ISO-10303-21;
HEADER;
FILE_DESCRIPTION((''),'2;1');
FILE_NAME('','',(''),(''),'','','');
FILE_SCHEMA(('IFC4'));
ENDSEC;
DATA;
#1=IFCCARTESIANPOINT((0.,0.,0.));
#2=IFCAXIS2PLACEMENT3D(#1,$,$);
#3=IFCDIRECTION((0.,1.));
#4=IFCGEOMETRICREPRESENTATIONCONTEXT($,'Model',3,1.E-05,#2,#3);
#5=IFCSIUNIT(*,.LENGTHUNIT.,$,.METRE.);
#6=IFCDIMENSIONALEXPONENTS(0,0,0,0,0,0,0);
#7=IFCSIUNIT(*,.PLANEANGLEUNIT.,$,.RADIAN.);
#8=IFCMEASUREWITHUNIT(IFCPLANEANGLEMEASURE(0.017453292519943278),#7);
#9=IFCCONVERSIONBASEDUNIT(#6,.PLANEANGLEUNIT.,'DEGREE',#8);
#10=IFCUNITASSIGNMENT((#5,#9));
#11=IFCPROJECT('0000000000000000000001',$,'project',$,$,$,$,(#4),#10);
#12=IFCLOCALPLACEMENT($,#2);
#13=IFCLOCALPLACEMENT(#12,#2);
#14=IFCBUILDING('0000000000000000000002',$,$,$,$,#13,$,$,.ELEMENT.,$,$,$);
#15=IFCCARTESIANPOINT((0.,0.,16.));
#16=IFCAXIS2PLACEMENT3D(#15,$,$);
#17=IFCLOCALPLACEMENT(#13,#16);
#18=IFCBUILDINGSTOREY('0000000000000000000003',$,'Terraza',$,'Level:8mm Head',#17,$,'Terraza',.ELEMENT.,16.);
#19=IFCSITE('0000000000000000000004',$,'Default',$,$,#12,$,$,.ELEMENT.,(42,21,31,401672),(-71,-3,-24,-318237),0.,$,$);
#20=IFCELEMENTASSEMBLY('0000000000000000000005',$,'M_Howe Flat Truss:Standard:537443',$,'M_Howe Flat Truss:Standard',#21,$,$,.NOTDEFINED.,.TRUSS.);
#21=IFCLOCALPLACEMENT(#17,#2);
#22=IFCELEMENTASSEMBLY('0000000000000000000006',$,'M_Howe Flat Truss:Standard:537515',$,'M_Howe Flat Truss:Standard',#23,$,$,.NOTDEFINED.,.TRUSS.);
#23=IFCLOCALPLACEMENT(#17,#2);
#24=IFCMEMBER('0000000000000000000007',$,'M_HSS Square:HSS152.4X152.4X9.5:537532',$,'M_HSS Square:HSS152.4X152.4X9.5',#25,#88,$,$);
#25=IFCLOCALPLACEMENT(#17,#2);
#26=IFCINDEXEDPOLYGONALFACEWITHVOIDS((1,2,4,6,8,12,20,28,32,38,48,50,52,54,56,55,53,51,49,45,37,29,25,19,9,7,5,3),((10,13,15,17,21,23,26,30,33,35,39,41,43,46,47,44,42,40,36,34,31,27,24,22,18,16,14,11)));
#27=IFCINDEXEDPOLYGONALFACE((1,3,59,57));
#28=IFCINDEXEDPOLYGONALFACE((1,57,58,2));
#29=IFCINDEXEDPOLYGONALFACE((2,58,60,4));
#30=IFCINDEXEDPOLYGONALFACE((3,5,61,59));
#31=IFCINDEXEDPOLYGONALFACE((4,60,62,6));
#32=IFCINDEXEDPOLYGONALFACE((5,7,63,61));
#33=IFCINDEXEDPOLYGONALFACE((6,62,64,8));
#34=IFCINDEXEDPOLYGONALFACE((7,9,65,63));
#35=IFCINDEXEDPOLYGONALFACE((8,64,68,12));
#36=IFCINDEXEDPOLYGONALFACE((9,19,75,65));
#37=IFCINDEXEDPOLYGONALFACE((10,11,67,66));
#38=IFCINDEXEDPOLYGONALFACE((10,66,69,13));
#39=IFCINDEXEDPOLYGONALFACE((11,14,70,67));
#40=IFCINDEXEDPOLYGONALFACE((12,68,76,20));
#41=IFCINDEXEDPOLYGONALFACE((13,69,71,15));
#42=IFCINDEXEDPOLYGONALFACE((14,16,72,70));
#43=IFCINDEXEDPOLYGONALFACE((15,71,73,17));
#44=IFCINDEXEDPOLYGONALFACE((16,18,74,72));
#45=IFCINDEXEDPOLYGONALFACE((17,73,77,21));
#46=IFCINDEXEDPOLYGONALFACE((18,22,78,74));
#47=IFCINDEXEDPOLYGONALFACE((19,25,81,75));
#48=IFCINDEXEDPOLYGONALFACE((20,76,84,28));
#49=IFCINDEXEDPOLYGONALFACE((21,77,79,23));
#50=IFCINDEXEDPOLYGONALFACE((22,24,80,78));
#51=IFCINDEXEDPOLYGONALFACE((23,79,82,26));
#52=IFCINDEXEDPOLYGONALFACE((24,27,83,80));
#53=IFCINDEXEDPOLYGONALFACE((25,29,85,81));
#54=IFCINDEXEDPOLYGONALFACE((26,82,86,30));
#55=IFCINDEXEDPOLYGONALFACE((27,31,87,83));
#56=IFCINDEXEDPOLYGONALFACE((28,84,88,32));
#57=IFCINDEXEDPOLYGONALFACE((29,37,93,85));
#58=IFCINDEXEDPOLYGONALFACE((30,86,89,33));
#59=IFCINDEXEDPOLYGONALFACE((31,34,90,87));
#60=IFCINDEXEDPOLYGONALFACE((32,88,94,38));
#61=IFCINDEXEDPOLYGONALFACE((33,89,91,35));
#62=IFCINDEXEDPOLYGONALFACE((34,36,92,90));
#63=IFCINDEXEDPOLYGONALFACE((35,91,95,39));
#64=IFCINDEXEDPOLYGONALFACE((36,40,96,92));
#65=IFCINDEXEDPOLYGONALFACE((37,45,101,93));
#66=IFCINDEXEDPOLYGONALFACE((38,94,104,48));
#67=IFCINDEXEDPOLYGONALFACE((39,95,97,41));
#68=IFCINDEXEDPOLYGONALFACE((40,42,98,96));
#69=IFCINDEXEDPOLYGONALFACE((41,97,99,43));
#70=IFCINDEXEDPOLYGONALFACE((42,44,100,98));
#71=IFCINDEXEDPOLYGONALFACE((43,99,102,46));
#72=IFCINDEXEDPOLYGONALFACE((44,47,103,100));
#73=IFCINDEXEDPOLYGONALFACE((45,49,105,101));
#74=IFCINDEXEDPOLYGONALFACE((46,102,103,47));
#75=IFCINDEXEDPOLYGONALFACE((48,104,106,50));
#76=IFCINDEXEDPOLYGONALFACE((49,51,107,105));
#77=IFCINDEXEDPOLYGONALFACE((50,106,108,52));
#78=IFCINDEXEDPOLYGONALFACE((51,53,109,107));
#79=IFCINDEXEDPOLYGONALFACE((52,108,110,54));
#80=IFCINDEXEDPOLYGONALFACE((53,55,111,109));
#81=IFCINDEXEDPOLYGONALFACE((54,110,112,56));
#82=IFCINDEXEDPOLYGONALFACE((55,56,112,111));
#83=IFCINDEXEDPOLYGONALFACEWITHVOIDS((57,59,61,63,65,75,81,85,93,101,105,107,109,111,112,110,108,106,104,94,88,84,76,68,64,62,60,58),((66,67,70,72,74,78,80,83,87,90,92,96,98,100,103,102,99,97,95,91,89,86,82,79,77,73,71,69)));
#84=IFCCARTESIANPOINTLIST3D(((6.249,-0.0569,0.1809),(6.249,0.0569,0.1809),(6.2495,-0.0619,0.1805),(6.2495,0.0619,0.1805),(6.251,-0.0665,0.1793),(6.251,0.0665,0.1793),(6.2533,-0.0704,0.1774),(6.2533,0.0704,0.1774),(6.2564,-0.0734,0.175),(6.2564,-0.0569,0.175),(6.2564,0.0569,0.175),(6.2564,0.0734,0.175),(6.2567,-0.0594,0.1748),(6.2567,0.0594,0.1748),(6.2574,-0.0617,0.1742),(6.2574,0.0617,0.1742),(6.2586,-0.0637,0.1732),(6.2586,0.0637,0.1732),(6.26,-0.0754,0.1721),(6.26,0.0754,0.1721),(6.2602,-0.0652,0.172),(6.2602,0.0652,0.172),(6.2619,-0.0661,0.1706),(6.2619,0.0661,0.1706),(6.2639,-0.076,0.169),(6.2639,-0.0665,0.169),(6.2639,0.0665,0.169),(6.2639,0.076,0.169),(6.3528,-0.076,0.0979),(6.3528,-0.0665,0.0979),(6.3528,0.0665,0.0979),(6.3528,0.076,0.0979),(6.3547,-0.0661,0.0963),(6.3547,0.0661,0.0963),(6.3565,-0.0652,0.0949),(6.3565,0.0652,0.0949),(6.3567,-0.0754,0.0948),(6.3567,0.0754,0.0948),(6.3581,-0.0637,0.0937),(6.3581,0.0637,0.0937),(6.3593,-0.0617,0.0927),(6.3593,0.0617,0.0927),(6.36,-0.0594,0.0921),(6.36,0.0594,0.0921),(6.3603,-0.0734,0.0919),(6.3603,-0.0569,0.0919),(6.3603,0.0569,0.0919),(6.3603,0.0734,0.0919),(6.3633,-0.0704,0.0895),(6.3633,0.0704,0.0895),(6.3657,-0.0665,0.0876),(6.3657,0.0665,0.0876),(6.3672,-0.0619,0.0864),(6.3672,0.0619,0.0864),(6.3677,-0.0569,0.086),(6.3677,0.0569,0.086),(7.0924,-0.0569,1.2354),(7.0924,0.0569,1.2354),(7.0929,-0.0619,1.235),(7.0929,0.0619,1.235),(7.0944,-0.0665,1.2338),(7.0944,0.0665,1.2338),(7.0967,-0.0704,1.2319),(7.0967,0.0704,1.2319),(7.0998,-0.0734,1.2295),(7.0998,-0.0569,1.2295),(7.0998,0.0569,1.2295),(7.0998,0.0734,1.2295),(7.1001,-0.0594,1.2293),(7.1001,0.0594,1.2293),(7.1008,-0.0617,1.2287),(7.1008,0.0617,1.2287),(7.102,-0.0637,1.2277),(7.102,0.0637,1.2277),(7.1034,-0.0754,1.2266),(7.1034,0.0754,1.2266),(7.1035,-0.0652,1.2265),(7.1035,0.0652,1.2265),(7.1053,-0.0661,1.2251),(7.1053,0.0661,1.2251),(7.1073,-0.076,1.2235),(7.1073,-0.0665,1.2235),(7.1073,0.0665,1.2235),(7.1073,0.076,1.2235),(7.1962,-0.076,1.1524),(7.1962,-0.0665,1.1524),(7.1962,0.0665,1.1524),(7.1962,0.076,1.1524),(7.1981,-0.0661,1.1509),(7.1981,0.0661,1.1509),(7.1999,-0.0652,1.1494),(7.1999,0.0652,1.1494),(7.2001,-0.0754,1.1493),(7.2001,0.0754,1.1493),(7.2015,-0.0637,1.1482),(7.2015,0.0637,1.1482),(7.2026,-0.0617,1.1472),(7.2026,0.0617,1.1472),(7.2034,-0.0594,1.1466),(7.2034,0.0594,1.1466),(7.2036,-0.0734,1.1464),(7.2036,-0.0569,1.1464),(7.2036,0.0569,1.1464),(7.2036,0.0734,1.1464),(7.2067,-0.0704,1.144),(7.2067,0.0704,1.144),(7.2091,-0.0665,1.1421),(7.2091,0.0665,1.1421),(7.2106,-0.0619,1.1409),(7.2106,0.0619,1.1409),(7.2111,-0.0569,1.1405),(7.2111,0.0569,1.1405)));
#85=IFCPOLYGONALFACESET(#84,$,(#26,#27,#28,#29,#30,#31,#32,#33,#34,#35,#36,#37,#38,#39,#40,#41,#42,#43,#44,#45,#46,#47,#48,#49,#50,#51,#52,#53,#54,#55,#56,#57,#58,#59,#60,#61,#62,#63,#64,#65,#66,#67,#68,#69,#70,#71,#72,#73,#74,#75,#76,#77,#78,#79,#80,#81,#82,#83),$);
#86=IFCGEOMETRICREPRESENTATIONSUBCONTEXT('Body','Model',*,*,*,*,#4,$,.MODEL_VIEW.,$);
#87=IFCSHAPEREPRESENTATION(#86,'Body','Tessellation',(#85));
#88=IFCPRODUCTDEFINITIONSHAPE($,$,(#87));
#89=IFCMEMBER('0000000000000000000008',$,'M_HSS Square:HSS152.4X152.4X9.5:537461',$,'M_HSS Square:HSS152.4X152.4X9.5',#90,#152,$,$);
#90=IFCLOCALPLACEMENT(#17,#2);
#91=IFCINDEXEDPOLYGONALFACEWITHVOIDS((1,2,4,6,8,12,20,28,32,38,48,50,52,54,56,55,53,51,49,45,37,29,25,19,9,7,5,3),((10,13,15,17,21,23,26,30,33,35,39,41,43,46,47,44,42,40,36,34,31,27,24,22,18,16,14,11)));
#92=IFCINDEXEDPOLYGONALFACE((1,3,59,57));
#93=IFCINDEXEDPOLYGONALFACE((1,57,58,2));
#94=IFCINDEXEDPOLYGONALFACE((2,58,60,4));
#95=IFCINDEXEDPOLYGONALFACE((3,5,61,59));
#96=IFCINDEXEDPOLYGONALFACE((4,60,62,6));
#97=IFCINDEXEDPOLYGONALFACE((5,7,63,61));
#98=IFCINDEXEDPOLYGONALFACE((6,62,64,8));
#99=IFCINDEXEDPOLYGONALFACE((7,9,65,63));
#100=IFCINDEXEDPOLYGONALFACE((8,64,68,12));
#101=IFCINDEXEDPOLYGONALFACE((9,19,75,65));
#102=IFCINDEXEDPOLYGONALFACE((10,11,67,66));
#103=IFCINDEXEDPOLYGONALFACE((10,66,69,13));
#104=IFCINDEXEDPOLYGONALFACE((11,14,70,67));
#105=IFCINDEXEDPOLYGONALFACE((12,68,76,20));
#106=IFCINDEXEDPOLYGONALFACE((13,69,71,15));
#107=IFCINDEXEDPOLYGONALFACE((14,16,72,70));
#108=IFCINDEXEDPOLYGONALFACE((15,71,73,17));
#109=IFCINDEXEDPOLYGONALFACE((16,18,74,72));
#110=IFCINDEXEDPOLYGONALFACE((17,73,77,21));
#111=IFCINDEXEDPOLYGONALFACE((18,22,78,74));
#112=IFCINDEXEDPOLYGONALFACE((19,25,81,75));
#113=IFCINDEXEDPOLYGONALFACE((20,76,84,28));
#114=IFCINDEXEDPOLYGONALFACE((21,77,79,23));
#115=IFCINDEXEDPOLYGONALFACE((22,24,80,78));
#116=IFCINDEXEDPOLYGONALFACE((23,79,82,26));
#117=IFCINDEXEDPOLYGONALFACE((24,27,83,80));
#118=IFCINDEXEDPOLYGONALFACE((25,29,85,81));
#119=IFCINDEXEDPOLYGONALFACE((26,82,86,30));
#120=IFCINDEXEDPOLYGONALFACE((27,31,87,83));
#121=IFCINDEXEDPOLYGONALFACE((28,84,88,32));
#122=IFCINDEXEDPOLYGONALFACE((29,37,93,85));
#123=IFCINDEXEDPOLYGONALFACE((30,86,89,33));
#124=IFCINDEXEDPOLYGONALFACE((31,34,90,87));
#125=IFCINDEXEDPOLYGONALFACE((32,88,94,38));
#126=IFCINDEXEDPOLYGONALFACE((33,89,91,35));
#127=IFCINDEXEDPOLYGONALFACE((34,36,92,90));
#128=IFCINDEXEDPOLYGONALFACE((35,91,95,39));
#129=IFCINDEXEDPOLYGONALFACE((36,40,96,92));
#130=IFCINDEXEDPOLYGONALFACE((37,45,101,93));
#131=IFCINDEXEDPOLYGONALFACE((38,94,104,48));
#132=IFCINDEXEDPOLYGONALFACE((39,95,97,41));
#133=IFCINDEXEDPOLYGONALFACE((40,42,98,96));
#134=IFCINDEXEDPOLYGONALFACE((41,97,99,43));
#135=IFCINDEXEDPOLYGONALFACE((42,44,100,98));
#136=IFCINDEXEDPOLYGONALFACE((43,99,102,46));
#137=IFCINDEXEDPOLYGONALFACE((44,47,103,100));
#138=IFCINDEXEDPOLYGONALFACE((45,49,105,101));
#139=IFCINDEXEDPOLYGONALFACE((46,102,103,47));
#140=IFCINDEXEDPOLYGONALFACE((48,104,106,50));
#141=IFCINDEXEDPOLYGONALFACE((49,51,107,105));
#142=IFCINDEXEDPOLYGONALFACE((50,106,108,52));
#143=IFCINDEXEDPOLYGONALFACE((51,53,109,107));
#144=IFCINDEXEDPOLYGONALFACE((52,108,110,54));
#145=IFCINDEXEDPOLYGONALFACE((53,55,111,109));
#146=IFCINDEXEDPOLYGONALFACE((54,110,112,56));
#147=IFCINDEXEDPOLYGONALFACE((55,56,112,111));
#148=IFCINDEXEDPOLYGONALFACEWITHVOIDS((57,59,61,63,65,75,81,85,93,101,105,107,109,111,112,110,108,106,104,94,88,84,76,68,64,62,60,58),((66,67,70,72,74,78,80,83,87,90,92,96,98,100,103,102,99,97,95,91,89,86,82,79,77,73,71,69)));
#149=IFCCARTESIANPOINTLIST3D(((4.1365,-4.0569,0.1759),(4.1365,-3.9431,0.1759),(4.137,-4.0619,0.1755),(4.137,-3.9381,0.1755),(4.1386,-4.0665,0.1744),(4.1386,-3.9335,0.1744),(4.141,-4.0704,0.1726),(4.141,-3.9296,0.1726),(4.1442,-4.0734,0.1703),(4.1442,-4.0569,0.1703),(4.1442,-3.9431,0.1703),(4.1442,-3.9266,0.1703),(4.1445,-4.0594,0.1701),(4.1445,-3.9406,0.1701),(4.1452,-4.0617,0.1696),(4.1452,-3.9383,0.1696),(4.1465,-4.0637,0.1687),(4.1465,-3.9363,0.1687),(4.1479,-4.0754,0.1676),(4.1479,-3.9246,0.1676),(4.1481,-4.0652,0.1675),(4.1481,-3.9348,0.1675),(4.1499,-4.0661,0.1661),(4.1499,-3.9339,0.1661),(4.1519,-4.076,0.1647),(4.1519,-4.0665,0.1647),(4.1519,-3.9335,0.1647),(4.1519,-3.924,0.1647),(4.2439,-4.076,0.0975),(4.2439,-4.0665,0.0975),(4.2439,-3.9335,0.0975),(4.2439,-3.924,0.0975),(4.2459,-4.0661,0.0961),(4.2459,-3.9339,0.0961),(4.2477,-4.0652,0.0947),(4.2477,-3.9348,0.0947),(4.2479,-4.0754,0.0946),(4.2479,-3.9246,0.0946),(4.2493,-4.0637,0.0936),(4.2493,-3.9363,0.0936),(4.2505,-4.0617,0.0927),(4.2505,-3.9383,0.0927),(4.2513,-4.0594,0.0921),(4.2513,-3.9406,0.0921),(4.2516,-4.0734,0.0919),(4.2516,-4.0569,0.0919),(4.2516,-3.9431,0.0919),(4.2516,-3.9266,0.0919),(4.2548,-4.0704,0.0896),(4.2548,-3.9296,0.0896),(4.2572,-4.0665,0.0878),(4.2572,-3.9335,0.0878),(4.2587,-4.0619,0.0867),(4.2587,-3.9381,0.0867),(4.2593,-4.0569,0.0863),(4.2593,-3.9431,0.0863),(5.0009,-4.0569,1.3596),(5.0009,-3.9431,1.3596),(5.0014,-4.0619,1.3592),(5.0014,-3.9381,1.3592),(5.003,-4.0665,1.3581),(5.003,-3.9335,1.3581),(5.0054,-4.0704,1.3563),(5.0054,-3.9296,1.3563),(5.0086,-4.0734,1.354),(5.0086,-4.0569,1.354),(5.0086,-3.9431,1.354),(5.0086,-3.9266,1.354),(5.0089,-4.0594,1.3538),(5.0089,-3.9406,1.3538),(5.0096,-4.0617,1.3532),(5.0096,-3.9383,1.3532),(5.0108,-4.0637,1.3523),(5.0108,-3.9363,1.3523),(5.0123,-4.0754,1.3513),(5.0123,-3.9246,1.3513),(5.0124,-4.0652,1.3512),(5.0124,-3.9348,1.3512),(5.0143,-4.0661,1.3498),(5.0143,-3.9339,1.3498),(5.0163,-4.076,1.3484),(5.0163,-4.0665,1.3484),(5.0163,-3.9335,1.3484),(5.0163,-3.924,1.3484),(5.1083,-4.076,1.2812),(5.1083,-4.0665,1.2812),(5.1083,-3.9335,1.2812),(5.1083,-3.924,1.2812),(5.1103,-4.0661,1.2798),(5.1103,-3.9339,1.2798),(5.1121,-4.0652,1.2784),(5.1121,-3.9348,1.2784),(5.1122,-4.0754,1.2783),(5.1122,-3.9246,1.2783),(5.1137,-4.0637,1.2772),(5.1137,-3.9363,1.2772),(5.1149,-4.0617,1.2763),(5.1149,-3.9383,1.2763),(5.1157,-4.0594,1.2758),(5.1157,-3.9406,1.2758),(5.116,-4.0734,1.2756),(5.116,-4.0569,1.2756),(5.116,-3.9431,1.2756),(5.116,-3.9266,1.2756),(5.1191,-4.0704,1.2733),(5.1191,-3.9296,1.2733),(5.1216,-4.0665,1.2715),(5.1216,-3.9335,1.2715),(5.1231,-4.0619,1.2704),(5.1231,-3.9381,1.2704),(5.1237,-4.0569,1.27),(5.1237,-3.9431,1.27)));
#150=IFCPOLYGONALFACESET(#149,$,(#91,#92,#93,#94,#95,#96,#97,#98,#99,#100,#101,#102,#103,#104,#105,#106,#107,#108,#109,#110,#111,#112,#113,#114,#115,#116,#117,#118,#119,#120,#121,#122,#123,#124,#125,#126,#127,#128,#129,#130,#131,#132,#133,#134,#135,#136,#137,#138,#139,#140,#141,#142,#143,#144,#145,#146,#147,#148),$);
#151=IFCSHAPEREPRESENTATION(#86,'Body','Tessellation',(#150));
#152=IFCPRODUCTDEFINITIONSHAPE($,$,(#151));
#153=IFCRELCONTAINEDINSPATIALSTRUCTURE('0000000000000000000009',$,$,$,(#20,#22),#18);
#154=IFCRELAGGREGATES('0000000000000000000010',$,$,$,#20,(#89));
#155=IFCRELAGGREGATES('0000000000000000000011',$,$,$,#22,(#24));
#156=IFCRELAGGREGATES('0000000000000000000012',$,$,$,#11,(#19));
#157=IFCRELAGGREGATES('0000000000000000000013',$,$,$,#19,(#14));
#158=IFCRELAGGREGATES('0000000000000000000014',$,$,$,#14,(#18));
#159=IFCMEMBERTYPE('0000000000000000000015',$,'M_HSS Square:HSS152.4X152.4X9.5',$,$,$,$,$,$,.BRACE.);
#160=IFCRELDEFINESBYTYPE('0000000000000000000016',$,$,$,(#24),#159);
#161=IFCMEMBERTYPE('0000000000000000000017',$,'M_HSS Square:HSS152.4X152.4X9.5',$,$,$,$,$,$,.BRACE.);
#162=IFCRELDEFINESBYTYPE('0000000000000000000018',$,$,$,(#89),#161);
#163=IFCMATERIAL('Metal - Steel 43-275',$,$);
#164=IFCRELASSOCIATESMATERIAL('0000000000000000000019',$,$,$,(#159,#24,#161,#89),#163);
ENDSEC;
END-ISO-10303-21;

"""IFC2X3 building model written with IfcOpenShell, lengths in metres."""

from ifc_helpers import new_model, entity, si_unit, converted_unit, direction, frame, frame_2d, origin, place, context, subcontext, project, spatial, polyline, circle_curve, parameter, trimmed, segment, composite_curve, outline, extrude, source, transform, mapped, material, type_object, type_shapes, element, aggregate, save


model = new_model("IFC2X3")

# Units and contexts
model_context = context("Model", 3, precision=1e-05, world=origin(), true_north=direction((0.0, 1.0)))
body_context = subcontext(model_context, "Body", "Model", "MODEL_VIEW")
ifc_project = project(units=[si_unit("LENGTHUNIT", "METRE"), converted_unit("PLANEANGLEUNIT", "DEGREE", entity("IfcPlaneAngleMeasure", 0.017453292519943278), si_unit("PLANEANGLEUNIT", "RADIAN"), dimensions=[0, 0, 0, 0, 0, 0, 0])], contexts=[model_context])

# Site, building, storey
site_placement = place(None, origin())
site = spatial("IfcSite", under=ifc_project, at=site_placement, Name="Default", CompositionType="ELEMENT", RefLatitude=(42, 21, 31, 401672), RefLongitude=(-71, -3, -24, -318237), RefElevation=0.0)
building_placement = place(site_placement, origin())
building = spatial("IfcBuilding", under=site, at=building_placement, CompositionType="ELEMENT")
storey_placement = place(building_placement, frame((0.0, 0.0, 16.0)))
storey = spatial("IfcBuildingStorey", under=building, at=storey_placement, Name="Terraza", ObjectType="Level:8mm Head", LongName="Terraza", CompositionType="ELEMENT", Elevation=16.0)

# Element assemblies
ifc_material_1 = material(Name="Metal - Steel 43-275")
assembly_1_placement = place(storey_placement, origin())
assembly_1 = element("IfcElementAssembly", 1, at=assembly_1_placement, inside=storey, Name="M_Howe Flat Truss:Standard:537443", ObjectType="M_Howe Flat Truss:Standard", AssemblyPlace="NOTDEFINED", PredefinedType="TRUSS")
assembly_2_placement = place(storey_placement, origin())
assembly_2 = element("IfcElementAssembly", 2, at=assembly_2_placement, inside=storey, Name="M_Howe Flat Truss:Standard:537515", ObjectType="M_Howe Flat Truss:Standard", AssemblyPlace="NOTDEFINED", PredefinedType="TRUSS")

# Members
member_type_1 = type_object("IfcMemberType", Name="M_HSS Square:HSS152.4X152.4X9.5", PredefinedType="BRACE", material=ifc_material_1)
shared_shape_1 = source(origin(), body_context, "Body", "SweptSolid", [
    extrude(outline(composite_curve([segment(polyline([(-0.0569, -0.076), (0.0569, -0.076)]), True, "CONTINUOUS"), segment(trimmed(circle_curve(frame_2d((0.0569, -0.0569), x_axis=(0.0, 1.0)), 0.0191), [parameter(180.0)], [parameter(270.0)], True, "PARAMETER"), True, "CONTINUOUS"), segment(polyline([(0.076, -0.0569), (0.076, 0.0569)]), True, "CONTINUOUS"), segment(trimmed(circle_curve(frame_2d((0.0569, 0.0569), x_axis=(0.0, 1.0)), 0.0191), [parameter(270.0)], [parameter(0.0)], True, "PARAMETER"), True, "CONTINUOUS"), segment(polyline([(0.0569, 0.076), (-0.0569, 0.076)]), True, "CONTINUOUS"), segment(trimmed(circle_curve(frame_2d((-0.0569, 0.0569), x_axis=(0.0, 1.0)), 0.0191), [parameter(0.0)], [parameter(90.0)], True, "PARAMETER"), True, "CONTINUOUS"), segment(polyline([(-0.076, 0.0569), (-0.076, -0.0569)]), True, "CONTINUOUS"), segment(trimmed(circle_curve(frame_2d((-0.0569, -0.0569), x_axis=(0.0, 1.0)), 0.0191), [parameter(90.0)], [parameter(180.0)], True, "PARAMETER"), True, "CONTINUOUS")], self_intersect=False), holes=[composite_curve([segment(trimmed(circle_curve(frame_2d((-0.0569, 0.0569), x_axis=(0.0, 1.0)), 0.0095), [parameter(360.0)], [parameter(90.0)], True, "PARAMETER"), False, "CONTINUOUS"), segment(polyline([(-0.0569, 0.0665), (0.0569, 0.0665)]), True, "CONTINUOUS"), segment(trimmed(circle_curve(frame_2d((0.0569, 0.0569), x_axis=(0.0, 1.0)), 0.0095), [parameter(270.0)], [parameter(360.0)], True, "PARAMETER"), False, "CONTINUOUS"), segment(polyline([(0.0665, 0.0569), (0.0665, -0.0569)]), True, "CONTINUOUS"), segment(trimmed(circle_curve(frame_2d((0.0569, -0.0569), x_axis=(0.0, 1.0)), 0.0095), [parameter(180.0)], [parameter(270.0)], True, "PARAMETER"), False, "CONTINUOUS"), segment(polyline([(0.0569, -0.0665), (-0.0569, -0.0665)]), True, "CONTINUOUS"), segment(trimmed(circle_curve(frame_2d((-0.0569, -0.0569), x_axis=(0.0, 1.0)), 0.0095), [parameter(90.0)], [parameter(180.0)], True, "PARAMETER"), False, "CONTINUOUS"), segment(polyline([(-0.0665, -0.0569), (-0.0665, 0.0569)]), True, "CONTINUOUS")], self_intersect=False)]), frame((-0.6695, 0.0, 0.0), z_axis=(1.0, 0.0, 0.0), x_axis=(0.0, 0.0, -1.0)), (0.0, 0.0, 1.0), 1.3503),
])
type_shapes(member_type_1, [shared_shape_1])
member_1_placement = place(assembly_2_placement, frame((6.7265, 0.0, 0.6562), z_axis=(0.780947, 0.0, -0.624598), x_axis=(0.624598, 0.0, 0.780947)))
member_1 = element("IfcMember", 3, at=member_1_placement, type_object=member_type_1, material=ifc_material_1, Name="M_HSS Square:HSS152.4X152.4X9.5:537532", ObjectType="M_HSS Square:HSS152.4X152.4X9.5", context=body_context, shape_type="MappedRepresentation", body=[
    mapped(shared_shape_1, transform((0.0, 0.0, 0.0), scale=1.0)),
])
member_type_2 = type_object("IfcMemberType", Name="M_HSS Square:HSS152.4X152.4X9.5", PredefinedType="BRACE", material=ifc_material_1)
shared_shape_2 = source(origin(), body_context, "Body", "SweptSolid", [
    extrude(outline(composite_curve([segment(polyline([(-0.0569, -0.076), (0.0569, -0.076)]), True, "CONTINUOUS"), segment(trimmed(circle_curve(frame_2d((0.0569, -0.0569), x_axis=(0.0, 1.0)), 0.0191), [parameter(180.0)], [parameter(270.0)], True, "PARAMETER"), True, "CONTINUOUS"), segment(polyline([(0.076, -0.0569), (0.076, 0.0569)]), True, "CONTINUOUS"), segment(trimmed(circle_curve(frame_2d((0.0569, 0.0569), x_axis=(0.0, 1.0)), 0.0191), [parameter(270.0)], [parameter(0.0)], True, "PARAMETER"), True, "CONTINUOUS"), segment(polyline([(0.0569, 0.076), (-0.0569, 0.076)]), True, "CONTINUOUS"), segment(trimmed(circle_curve(frame_2d((-0.0569, 0.0569), x_axis=(0.0, 1.0)), 0.0191), [parameter(0.0)], [parameter(90.0)], True, "PARAMETER"), True, "CONTINUOUS"), segment(polyline([(-0.076, 0.0569), (-0.076, -0.0569)]), True, "CONTINUOUS"), segment(trimmed(circle_curve(frame_2d((-0.0569, -0.0569), x_axis=(0.0, 1.0)), 0.0191), [parameter(90.0)], [parameter(180.0)], True, "PARAMETER"), True, "CONTINUOUS")], self_intersect=False), holes=[composite_curve([segment(trimmed(circle_curve(frame_2d((-0.0569, 0.0569), x_axis=(0.0, 1.0)), 0.0095), [parameter(360.0)], [parameter(90.0)], True, "PARAMETER"), False, "CONTINUOUS"), segment(polyline([(-0.0569, 0.0665), (0.0569, 0.0665)]), True, "CONTINUOUS"), segment(trimmed(circle_curve(frame_2d((0.0569, 0.0569), x_axis=(0.0, 1.0)), 0.0095), [parameter(270.0)], [parameter(360.0)], True, "PARAMETER"), False, "CONTINUOUS"), segment(polyline([(0.0665, 0.0569), (0.0665, -0.0569)]), True, "CONTINUOUS"), segment(trimmed(circle_curve(frame_2d((0.0569, -0.0569), x_axis=(0.0, 1.0)), 0.0095), [parameter(180.0)], [parameter(270.0)], True, "PARAMETER"), False, "CONTINUOUS"), segment(polyline([(0.0569, -0.0665), (-0.0569, -0.0665)]), True, "CONTINUOUS"), segment(trimmed(circle_curve(frame_2d((-0.0569, -0.0569), x_axis=(0.0, 1.0)), 0.0095), [parameter(90.0)], [parameter(180.0)], True, "PARAMETER"), False, "CONTINUOUS"), segment(polyline([(-0.0665, -0.0569), (-0.0665, 0.0569)]), True, "CONTINUOUS")], self_intersect=False)]), frame((-0.7277, 0.0, 0.0), z_axis=(1.0, 0.0, 0.0), x_axis=(0.0, 0.0, -1.0)), (0.0, 0.0, 1.0), 1.4657),
])
type_shapes(member_type_2, [shared_shape_2])
member_2_placement = place(assembly_1_placement, frame((4.627, -4.0, 0.7187), z_axis=(0.807592, 0.0, -0.589742), x_axis=(0.589742, 0.0, 0.807592)))
member_2 = element("IfcMember", 4, at=member_2_placement, type_object=member_type_2, material=ifc_material_1, Name="M_HSS Square:HSS152.4X152.4X9.5:537461", ObjectType="M_HSS Square:HSS152.4X152.4X9.5", context=body_context, shape_type="MappedRepresentation", body=[
    mapped(shared_shape_2, transform((0.0, 0.0, 0.0), scale=1.0)),
])
aggregate(assembly_1, [member_2])
aggregate(assembly_2, [member_1])

save(model, "model.ifc")
